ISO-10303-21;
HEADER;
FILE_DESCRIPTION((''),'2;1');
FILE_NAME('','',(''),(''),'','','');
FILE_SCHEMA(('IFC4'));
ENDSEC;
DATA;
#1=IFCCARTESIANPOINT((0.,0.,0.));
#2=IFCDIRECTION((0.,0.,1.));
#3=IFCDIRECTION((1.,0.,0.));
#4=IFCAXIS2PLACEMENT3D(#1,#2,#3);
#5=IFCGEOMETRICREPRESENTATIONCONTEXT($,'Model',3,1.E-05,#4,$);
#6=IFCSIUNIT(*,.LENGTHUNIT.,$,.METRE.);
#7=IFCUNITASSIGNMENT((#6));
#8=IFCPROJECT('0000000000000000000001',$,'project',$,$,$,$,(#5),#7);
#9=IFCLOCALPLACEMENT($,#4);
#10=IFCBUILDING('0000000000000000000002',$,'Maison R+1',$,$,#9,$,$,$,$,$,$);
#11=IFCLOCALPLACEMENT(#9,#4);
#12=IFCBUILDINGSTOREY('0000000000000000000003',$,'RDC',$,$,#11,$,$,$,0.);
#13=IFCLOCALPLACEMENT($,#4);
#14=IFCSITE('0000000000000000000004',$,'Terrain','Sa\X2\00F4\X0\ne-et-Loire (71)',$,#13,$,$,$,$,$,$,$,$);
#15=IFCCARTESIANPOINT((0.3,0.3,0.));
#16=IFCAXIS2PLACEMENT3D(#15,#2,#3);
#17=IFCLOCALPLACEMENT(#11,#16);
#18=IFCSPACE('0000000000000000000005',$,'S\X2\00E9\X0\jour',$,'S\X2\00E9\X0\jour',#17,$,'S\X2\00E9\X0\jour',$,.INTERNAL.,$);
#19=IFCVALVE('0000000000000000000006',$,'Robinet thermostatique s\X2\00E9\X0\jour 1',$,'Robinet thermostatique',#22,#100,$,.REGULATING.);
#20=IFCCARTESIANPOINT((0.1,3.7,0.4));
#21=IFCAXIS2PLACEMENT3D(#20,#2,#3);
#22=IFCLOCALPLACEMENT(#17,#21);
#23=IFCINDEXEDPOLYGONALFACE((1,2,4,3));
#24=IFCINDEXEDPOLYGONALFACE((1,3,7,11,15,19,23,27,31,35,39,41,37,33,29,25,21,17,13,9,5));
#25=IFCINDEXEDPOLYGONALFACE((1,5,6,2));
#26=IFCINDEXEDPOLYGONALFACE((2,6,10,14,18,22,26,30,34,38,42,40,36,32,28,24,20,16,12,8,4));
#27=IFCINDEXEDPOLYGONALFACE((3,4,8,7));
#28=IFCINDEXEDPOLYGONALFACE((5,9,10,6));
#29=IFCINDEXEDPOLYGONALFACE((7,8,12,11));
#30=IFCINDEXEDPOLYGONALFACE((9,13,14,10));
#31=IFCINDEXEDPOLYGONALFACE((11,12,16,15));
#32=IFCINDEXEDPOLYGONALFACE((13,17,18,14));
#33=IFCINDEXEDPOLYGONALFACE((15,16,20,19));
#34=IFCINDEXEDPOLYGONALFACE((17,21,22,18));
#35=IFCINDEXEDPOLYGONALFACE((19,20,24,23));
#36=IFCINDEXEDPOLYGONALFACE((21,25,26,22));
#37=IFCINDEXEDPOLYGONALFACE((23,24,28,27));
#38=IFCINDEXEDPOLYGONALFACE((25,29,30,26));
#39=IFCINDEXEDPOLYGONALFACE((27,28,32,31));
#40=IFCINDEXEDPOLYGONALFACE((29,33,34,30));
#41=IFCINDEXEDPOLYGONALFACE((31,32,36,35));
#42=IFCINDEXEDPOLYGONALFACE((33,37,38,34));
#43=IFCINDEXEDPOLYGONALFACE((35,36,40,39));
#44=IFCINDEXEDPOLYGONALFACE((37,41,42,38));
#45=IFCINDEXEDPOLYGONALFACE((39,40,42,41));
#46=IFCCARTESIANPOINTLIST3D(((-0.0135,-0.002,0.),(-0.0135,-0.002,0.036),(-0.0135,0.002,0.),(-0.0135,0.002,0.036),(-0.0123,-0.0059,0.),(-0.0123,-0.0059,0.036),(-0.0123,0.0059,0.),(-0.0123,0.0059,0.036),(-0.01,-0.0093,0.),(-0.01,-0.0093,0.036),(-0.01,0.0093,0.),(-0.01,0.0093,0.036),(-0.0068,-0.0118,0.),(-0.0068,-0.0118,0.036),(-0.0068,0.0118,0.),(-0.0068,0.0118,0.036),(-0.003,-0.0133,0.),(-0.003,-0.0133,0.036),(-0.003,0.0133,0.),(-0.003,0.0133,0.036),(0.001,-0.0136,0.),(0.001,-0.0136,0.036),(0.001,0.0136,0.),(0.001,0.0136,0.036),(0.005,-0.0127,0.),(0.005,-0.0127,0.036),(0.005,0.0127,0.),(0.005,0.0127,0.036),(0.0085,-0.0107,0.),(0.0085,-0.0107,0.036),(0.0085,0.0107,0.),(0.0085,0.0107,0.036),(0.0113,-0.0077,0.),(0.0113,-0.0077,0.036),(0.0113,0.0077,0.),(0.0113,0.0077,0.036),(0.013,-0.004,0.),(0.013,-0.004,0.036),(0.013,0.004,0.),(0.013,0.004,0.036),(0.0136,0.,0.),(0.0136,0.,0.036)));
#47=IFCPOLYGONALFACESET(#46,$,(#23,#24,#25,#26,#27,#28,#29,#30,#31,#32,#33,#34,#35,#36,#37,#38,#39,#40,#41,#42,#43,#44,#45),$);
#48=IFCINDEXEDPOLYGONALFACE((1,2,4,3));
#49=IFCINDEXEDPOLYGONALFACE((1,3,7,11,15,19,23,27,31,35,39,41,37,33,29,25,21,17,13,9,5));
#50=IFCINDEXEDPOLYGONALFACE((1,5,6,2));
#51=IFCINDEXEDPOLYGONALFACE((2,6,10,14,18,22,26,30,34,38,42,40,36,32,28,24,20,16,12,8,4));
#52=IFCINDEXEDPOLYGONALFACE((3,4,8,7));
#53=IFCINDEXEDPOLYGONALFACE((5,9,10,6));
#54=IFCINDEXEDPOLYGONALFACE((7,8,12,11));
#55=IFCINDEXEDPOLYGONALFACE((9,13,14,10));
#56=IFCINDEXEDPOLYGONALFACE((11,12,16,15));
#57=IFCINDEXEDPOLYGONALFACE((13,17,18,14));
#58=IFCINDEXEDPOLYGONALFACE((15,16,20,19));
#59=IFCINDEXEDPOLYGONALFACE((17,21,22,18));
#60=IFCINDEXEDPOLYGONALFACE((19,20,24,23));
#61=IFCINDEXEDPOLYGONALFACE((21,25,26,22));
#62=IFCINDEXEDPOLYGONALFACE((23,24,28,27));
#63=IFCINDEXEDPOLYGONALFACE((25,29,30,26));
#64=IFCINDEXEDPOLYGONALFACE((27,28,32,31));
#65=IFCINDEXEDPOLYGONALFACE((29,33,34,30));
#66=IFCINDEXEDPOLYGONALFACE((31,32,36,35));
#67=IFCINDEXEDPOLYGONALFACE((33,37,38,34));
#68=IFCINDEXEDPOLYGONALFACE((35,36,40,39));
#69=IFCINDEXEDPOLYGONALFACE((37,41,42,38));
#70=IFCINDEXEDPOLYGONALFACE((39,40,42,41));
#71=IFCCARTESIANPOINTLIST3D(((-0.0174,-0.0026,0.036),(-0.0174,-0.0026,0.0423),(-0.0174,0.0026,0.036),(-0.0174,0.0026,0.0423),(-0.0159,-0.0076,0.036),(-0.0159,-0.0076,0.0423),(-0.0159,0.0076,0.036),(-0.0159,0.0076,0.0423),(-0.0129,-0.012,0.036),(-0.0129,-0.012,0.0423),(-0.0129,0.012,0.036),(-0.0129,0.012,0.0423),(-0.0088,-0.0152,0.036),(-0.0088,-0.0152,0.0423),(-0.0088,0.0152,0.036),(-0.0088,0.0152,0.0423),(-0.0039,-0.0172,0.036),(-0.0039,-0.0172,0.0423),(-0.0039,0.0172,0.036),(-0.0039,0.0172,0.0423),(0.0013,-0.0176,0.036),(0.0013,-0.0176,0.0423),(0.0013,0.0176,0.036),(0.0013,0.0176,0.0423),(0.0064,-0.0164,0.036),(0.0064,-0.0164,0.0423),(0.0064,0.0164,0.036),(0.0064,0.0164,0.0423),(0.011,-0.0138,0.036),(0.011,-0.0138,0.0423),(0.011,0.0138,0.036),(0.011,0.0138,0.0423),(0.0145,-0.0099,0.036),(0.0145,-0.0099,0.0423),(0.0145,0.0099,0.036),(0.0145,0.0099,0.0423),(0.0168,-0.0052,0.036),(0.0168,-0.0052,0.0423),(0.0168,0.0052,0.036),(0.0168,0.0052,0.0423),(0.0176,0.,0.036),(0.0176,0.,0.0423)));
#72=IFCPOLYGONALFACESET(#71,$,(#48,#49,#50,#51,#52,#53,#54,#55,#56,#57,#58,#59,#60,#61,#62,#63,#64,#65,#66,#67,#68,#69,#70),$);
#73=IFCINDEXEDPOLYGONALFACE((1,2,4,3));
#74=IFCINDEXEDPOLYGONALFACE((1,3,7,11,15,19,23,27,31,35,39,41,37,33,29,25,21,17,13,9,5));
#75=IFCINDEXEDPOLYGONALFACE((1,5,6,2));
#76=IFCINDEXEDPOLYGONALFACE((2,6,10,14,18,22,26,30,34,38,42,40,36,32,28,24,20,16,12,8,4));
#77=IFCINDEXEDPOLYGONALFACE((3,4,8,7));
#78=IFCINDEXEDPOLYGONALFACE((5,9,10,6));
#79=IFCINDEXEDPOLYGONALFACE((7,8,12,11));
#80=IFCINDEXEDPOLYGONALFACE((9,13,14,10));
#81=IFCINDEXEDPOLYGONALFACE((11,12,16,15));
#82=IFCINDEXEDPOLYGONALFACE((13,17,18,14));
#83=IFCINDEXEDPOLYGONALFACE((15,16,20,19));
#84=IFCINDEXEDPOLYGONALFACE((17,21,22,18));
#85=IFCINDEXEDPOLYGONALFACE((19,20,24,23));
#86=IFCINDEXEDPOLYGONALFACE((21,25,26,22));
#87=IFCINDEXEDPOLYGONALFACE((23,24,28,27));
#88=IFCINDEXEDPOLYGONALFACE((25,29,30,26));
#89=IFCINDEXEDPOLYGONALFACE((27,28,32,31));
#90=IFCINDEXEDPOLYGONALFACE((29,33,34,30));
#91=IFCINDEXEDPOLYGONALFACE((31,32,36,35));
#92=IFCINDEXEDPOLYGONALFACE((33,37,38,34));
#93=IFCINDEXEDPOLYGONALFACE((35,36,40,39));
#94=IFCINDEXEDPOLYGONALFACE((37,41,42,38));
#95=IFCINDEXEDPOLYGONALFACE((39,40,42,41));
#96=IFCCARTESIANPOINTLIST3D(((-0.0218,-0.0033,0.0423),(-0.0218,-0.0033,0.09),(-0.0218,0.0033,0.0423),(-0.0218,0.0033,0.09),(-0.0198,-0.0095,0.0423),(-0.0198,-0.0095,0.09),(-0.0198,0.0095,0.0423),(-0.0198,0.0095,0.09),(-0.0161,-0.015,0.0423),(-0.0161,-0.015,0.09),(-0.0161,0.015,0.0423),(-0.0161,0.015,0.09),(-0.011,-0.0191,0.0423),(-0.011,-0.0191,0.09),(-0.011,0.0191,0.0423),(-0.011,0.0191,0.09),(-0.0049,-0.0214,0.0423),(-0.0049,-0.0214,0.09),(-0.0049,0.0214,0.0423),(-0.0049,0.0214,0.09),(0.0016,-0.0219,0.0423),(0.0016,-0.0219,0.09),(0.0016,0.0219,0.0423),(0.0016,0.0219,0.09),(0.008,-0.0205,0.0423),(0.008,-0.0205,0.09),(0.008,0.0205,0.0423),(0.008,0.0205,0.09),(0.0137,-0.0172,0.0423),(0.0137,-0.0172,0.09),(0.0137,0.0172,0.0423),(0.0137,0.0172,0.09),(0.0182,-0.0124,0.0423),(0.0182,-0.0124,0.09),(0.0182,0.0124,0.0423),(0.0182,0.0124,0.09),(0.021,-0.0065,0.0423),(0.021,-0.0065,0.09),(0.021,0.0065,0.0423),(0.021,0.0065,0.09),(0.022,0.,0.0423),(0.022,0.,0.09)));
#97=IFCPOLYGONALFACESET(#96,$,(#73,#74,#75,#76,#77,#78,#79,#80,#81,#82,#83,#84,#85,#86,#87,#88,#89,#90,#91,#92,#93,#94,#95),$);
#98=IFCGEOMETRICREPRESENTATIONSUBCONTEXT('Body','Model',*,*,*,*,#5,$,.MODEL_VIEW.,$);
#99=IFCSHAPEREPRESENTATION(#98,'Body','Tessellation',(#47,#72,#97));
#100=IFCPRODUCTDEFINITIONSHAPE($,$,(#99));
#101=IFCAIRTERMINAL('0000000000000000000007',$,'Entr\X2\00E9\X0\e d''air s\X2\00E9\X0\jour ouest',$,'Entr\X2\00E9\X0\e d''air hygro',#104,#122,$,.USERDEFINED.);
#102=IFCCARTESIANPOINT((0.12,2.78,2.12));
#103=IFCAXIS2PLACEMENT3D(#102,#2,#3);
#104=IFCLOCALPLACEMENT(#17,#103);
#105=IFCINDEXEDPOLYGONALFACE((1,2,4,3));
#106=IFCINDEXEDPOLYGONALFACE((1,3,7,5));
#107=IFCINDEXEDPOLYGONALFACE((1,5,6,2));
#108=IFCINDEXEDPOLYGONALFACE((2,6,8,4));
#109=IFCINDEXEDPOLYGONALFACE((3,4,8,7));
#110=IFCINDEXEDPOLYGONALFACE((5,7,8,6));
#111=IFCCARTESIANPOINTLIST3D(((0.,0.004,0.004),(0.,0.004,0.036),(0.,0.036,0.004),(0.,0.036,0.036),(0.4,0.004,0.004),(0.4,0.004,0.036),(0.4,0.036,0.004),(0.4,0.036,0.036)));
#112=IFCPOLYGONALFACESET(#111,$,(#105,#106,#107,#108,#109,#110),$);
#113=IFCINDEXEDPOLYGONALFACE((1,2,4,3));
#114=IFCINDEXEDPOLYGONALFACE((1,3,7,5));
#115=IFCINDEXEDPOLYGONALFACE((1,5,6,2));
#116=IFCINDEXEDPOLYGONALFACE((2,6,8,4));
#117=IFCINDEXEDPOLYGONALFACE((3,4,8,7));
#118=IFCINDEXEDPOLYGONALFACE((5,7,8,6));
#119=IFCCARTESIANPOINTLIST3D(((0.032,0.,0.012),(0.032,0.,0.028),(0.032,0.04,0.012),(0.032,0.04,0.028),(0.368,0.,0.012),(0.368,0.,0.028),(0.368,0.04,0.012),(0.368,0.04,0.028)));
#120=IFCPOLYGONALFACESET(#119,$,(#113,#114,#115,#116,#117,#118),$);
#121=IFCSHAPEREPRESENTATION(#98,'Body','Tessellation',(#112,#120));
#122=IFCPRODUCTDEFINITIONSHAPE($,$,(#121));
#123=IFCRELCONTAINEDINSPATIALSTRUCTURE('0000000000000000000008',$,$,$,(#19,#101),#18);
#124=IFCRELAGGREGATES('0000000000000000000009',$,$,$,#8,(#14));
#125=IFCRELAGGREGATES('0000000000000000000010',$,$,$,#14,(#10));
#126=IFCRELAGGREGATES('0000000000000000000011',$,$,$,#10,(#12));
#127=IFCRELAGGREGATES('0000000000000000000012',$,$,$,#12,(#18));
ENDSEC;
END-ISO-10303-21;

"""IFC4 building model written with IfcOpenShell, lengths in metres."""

from ifc_helpers import new_model, si_unit, frame, frame_2d, origin_with_axes, place, context, subcontext, project, spatial, rectangle, circle, extrude, element, save


model = new_model("IFC4")

# Units and contexts
model_context = context("Model", 3, precision=1e-05, world=origin_with_axes())
body_context = subcontext(model_context, "Body", "Model", "MODEL_VIEW")
ifc_project = project(units=[si_unit("LENGTHUNIT", "METRE")], contexts=[model_context])

# Site, building, storey
site_placement = place(None, origin_with_axes())
site = spatial("IfcSite", under=ifc_project, at=site_placement, Name="Terrain", Description="Saône-et-Loire (71)")
building_placement = place(None, origin_with_axes())
building = spatial("IfcBuilding", under=site, at=building_placement, Name="Maison R+1")
storey_placement = place(building_placement, origin_with_axes())
storey = spatial("IfcBuildingStorey", under=building, at=storey_placement, Name="RDC", Elevation=0.0)

# Shared definitions
space_placement = place(storey_placement, frame((0.3, 0.3, 0.0), z_axis=(0.0, 0.0, 1.0), x_axis=(1.0, 0.0, 0.0)))
space = spatial("IfcSpace", under=storey, at=space_placement, Name="Séjour", ObjectType="Séjour", LongName="Séjour", PredefinedType="INTERNAL")

# Valve
valve_1_placement = place(space_placement, frame((0.1, 3.7, 0.4), z_axis=(0.0, 0.0, 1.0), x_axis=(1.0, 0.0, 0.0)))
element("IfcValve", 1, at=valve_1_placement, inside=space, Name="Robinet thermostatique séjour 1", ObjectType="Robinet thermostatique", PredefinedType="REGULATING", context=body_context, shape_type="SweptSolid", body=[
    extrude(circle(Radius=0.0136), origin_with_axes(), (0.0, 0.0, 1.0), 0.036),
    extrude(circle(Radius=0.0176), frame((0.0, 0.0, 0.036), z_axis=(0.0, 0.0, 1.0), x_axis=(1.0, 0.0, 0.0)), (0.0, 0.0, 1.0), 0.0063),
    extrude(circle(Radius=0.022), frame((0.0, 0.0, 0.0423), z_axis=(0.0, 0.0, 1.0), x_axis=(1.0, 0.0, 0.0)), (0.0, 0.0, 1.0), 0.0477),
])

# Air terminal
air_terminal_placement = place(space_placement, frame((0.12, 2.78, 2.12), z_axis=(0.0, 0.0, 1.0), x_axis=(1.0, 0.0, 0.0)))
element("IfcAirTerminal", 2, at=air_terminal_placement, inside=space, Name="Entrée d'air séjour ouest", ObjectType="Entrée d'air hygro", PredefinedType="USERDEFINED", context=body_context, shape_type="SweptSolid", body=[
    extrude(rectangle(XDim=0.4, YDim=0.032, at=frame_2d((0.2, 0.016))), frame((0.0, 0.004, 0.004), z_axis=(0.0, 0.0, 1.0), x_axis=(1.0, 0.0, 0.0)), (0.0, 0.0, 1.0), 0.032),
    extrude(rectangle(XDim=0.336, YDim=0.04, at=frame_2d((0.168, 0.02))), frame((0.032, 0.0, 0.012), z_axis=(0.0, 0.0, 1.0), x_axis=(1.0, 0.0, 0.0)), (0.0, 0.0, 1.0), 0.016),
])

save(model, "model.ifc")
